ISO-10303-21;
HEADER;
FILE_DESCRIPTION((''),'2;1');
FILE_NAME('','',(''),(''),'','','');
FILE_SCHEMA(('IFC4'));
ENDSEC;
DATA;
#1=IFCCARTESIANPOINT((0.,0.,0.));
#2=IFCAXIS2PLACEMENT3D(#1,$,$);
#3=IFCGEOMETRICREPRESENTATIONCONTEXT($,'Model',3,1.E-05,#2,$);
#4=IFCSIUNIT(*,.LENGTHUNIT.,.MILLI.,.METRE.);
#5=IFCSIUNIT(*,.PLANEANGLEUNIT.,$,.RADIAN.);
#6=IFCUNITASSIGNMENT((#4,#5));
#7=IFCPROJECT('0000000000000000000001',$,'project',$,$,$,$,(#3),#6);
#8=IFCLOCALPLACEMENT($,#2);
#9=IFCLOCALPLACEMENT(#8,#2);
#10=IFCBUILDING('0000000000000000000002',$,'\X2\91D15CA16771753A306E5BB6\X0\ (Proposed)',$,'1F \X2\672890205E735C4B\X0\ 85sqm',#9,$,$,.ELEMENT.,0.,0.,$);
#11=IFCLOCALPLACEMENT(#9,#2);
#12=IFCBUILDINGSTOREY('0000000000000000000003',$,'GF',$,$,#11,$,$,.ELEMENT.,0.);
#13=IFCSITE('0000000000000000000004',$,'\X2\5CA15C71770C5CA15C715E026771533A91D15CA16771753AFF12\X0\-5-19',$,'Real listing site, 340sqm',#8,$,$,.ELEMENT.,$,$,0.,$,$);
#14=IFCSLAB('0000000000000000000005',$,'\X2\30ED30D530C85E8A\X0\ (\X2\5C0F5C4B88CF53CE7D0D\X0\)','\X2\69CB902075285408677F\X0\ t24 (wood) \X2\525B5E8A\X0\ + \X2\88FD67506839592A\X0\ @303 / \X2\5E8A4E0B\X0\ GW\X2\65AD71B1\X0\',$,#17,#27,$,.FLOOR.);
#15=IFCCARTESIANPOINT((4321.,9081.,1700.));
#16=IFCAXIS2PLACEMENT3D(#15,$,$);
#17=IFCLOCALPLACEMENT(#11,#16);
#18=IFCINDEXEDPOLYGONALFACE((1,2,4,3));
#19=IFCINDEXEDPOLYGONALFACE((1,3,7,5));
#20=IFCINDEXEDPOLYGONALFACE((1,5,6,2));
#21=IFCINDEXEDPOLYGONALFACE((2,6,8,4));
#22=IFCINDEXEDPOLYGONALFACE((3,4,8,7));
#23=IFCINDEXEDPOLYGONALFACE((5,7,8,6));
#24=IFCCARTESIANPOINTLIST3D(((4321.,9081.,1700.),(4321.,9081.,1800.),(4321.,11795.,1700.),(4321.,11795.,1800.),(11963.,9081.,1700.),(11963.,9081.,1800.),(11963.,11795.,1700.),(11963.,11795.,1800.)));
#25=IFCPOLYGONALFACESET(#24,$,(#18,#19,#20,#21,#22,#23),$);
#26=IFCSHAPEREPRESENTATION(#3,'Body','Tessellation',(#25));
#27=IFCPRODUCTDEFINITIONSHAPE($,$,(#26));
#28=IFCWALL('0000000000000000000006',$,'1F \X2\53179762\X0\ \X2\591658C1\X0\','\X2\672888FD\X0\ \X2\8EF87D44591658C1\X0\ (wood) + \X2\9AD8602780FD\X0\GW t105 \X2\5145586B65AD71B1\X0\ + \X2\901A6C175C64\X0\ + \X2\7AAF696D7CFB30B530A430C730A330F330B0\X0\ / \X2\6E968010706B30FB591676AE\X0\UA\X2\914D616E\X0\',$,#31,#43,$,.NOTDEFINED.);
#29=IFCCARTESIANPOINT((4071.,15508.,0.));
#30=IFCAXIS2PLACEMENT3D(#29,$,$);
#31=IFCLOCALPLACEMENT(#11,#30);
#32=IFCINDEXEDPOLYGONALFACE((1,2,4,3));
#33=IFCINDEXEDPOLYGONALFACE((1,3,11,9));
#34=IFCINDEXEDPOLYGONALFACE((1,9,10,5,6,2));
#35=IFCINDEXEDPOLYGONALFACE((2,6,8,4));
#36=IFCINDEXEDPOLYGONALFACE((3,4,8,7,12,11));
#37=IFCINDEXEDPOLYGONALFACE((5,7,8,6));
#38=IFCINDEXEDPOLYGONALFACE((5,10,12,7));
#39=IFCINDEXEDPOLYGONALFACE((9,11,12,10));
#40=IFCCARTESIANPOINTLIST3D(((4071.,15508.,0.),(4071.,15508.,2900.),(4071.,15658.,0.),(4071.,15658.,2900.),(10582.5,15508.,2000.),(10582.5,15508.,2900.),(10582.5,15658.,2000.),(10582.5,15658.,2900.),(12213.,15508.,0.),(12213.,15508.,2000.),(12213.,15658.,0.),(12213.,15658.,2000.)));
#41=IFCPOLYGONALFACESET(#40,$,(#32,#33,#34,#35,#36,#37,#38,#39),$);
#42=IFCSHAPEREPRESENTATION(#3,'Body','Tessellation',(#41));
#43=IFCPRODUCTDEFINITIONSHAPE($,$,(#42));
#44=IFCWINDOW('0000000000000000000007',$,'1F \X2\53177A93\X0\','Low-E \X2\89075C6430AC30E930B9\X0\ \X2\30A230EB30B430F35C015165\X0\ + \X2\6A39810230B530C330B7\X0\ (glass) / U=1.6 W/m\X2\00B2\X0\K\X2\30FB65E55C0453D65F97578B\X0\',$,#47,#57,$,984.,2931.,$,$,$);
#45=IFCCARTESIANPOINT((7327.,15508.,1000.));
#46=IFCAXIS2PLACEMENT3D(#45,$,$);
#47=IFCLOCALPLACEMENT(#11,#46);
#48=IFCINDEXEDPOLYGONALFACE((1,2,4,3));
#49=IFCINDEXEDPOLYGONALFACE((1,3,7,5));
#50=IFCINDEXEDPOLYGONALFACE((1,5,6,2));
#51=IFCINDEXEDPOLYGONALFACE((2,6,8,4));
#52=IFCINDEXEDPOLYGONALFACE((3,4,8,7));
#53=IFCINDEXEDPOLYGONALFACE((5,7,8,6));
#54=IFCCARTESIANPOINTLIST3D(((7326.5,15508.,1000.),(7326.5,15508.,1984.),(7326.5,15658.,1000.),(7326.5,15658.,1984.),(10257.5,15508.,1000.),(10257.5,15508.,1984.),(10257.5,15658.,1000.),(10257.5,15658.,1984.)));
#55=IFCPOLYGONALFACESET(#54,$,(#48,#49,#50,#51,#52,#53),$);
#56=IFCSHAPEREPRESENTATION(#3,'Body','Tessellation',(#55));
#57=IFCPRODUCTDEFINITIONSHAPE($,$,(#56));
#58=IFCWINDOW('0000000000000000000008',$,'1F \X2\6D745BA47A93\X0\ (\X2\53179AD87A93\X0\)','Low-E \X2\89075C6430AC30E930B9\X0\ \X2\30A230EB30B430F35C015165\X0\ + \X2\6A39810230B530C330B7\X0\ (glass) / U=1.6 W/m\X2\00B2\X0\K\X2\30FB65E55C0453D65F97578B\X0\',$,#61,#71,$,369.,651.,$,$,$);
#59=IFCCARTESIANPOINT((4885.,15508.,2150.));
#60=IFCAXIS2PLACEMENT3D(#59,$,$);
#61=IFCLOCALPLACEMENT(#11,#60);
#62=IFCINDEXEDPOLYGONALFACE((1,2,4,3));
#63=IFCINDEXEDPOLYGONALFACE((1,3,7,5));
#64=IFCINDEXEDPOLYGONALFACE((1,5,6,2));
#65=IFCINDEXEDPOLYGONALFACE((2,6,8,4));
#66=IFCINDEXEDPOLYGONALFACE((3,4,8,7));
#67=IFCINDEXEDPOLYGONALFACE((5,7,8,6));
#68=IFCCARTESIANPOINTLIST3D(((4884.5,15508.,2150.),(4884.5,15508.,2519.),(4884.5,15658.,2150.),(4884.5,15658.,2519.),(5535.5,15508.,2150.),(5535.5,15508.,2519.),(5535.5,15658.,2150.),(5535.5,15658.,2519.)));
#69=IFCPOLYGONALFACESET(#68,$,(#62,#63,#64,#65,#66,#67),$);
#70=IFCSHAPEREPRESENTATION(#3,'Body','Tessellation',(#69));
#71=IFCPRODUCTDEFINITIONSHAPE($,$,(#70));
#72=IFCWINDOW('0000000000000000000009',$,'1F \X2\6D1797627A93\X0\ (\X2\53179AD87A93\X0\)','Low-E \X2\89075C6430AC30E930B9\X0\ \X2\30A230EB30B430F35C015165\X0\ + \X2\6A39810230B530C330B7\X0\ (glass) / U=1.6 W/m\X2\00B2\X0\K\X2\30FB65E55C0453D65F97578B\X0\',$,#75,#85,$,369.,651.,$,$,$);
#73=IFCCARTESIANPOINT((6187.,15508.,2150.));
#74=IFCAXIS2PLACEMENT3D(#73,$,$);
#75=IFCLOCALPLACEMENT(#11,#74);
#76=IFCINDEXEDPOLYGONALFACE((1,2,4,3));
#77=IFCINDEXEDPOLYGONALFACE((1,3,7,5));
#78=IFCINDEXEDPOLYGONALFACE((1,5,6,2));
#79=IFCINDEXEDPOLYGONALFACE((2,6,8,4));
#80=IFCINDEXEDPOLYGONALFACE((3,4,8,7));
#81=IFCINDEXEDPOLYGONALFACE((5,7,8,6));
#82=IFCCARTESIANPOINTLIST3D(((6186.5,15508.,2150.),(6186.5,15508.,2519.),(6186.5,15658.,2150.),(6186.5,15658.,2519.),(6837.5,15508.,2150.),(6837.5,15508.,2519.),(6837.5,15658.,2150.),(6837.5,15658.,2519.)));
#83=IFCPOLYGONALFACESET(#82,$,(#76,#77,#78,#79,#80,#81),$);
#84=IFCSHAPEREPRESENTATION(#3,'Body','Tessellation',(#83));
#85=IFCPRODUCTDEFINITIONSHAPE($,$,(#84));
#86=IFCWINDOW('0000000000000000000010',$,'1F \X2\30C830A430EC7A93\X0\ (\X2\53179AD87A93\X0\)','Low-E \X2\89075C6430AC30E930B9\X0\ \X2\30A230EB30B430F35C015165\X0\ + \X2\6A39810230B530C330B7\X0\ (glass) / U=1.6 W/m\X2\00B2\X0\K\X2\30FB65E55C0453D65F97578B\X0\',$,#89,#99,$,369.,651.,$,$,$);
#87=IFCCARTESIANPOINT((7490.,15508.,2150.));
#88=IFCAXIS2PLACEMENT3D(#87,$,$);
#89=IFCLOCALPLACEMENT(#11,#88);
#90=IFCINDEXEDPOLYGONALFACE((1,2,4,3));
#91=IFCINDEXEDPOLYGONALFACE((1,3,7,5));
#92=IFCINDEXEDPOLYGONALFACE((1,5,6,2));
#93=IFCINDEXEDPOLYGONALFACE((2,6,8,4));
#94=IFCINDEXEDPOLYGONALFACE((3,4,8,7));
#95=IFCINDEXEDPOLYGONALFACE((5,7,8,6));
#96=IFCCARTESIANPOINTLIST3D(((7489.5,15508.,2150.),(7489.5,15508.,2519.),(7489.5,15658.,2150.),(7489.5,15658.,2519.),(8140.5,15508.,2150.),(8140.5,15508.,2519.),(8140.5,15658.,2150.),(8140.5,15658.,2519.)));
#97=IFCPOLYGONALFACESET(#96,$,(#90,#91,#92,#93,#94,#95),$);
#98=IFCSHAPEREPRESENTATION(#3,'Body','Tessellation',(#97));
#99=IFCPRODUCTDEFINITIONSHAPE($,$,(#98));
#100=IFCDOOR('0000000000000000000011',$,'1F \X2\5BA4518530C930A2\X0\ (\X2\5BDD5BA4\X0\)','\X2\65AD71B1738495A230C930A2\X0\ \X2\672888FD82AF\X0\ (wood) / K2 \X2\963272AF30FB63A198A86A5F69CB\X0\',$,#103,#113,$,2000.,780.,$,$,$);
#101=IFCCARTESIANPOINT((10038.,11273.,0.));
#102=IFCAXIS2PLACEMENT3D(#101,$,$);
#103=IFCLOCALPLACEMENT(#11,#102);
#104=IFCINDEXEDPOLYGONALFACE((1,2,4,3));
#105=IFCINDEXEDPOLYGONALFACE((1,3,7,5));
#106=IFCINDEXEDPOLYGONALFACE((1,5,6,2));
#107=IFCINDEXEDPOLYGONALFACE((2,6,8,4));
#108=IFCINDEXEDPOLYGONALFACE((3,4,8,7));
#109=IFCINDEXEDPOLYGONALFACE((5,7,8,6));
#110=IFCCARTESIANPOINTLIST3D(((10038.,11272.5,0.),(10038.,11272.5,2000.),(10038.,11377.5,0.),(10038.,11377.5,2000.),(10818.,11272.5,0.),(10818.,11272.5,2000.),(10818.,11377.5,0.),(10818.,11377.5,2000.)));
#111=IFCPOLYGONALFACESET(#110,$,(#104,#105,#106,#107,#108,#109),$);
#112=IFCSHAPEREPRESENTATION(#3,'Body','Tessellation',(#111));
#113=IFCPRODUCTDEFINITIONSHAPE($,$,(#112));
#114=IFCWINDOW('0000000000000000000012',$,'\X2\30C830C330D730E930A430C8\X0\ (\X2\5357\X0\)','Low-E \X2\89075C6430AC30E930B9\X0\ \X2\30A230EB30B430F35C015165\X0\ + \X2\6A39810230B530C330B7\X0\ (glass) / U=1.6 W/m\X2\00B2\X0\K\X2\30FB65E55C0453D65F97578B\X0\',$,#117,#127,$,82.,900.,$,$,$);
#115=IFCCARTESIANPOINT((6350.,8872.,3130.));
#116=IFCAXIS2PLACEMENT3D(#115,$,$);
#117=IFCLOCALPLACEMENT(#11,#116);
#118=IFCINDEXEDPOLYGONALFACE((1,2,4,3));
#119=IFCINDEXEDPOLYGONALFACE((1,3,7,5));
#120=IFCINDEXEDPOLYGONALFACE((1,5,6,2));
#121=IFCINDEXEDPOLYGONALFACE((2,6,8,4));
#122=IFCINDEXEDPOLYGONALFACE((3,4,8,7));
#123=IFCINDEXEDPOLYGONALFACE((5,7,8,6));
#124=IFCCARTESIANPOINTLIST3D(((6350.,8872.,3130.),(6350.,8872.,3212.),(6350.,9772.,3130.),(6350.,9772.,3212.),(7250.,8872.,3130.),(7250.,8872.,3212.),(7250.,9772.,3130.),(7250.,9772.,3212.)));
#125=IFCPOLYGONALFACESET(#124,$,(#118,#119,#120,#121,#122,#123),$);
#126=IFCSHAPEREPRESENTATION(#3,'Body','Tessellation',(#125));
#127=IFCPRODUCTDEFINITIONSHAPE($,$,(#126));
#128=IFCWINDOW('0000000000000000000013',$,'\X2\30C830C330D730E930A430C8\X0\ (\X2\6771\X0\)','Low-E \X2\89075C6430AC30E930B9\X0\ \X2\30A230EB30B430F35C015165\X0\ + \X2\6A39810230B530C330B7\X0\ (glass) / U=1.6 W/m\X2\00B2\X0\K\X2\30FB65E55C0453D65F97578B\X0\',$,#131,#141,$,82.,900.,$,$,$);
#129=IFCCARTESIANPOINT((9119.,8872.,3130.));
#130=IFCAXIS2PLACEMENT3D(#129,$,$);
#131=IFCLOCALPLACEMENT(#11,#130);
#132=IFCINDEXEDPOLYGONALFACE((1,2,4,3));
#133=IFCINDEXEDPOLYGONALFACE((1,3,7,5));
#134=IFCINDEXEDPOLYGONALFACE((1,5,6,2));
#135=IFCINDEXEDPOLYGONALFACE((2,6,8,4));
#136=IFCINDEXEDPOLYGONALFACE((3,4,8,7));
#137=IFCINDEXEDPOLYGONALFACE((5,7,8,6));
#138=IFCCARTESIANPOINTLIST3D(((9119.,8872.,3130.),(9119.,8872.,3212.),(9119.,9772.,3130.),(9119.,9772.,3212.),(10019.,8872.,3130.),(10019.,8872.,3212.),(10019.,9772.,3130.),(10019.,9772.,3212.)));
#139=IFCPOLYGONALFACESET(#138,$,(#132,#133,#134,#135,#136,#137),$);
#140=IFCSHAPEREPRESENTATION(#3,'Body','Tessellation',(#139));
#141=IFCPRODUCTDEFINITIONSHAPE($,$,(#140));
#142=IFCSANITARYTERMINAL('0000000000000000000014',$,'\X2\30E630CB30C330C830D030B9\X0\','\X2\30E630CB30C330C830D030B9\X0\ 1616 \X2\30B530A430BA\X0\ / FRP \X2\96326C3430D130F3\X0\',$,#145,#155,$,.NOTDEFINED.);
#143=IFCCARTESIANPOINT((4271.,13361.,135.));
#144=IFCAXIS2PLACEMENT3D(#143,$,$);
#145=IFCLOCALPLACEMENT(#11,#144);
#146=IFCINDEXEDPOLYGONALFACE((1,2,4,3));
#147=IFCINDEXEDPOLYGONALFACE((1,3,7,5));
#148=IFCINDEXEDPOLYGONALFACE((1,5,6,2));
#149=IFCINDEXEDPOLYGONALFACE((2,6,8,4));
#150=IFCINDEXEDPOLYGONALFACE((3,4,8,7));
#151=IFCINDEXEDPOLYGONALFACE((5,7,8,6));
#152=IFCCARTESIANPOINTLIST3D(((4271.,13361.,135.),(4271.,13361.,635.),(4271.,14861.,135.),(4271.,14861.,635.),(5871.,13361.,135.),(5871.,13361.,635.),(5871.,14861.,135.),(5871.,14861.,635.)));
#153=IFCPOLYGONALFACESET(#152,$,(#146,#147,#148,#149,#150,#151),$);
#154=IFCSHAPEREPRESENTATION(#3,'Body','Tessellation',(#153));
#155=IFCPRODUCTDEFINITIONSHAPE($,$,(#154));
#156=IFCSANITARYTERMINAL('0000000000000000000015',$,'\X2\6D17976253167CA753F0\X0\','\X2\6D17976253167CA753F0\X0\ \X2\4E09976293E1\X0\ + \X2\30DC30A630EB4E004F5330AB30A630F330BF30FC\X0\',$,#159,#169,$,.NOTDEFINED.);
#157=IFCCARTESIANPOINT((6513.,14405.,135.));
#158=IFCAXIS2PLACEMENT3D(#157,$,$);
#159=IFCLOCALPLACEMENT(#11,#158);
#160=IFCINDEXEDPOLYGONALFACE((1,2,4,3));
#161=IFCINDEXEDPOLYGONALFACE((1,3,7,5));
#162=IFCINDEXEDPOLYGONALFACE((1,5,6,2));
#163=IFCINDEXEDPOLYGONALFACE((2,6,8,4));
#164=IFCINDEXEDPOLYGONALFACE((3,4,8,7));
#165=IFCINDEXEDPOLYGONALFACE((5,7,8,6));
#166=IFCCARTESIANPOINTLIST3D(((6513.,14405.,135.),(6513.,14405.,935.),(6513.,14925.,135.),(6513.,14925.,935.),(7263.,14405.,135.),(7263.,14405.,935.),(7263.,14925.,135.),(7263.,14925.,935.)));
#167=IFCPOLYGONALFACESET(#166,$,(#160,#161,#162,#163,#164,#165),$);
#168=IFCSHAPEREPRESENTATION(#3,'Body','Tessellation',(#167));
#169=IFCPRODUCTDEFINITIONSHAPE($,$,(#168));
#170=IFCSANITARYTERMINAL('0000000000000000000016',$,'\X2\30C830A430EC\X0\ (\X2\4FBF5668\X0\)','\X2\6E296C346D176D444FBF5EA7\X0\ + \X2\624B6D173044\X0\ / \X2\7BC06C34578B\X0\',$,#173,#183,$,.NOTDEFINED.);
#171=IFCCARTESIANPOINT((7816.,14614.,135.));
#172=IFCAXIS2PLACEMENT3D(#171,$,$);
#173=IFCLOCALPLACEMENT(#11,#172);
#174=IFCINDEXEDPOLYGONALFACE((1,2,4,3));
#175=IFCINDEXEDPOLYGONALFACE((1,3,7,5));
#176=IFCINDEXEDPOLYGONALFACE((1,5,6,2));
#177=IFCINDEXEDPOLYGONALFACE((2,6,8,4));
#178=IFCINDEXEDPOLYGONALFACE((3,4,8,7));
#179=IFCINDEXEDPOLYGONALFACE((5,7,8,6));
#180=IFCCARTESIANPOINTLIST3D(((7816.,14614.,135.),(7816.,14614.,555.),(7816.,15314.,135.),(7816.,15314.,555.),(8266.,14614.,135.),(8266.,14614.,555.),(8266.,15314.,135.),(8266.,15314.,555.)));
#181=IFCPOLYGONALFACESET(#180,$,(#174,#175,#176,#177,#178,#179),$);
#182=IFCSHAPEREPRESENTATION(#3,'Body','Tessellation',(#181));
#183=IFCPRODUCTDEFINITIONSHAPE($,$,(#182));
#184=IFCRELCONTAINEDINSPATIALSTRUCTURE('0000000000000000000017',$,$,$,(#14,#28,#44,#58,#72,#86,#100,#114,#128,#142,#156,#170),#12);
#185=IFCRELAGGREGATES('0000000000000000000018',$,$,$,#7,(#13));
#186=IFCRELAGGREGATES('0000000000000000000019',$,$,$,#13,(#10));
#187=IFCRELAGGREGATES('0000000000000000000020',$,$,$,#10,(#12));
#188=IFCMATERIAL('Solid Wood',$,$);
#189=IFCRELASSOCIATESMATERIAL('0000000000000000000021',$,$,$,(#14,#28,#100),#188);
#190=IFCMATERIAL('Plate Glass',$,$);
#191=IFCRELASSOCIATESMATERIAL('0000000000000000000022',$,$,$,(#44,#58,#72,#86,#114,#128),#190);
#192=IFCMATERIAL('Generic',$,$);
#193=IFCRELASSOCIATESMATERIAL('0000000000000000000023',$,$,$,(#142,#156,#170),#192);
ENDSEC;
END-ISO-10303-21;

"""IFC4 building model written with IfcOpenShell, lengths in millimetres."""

from ifc_helpers import new_model, si_unit, frame, frame_2d, origin, place, context, project, spatial, rectangle, extrude, material, element, fill, save


model = new_model("IFC4")

# Units and contexts
model_context = context("Model", 3, precision=1e-05, world=origin())
ifc_project = project(units=[si_unit("LENGTHUNIT", "METRE", prefix="MILLI"), si_unit("PLANEANGLEUNIT", "RADIAN")], contexts=[model_context])

# Site, building, storey
site_placement = place(None, origin())
site = spatial("IfcSite", under=ifc_project, at=site_placement, Name="岡山県岡山市東区金岡東町２-5-19", ObjectType="Real listing site, 340sqm", CompositionType="ELEMENT", RefElevation=0.0)
building_placement = place(site_placement, origin())
building = spatial("IfcBuilding", under=site, at=building_placement, Name="金岡東町の家 (Proposed)", ObjectType="1F 木造平屋 85sqm", CompositionType="ELEMENT", ElevationOfRefHeight=0.0, ElevationOfTerrain=0.0)
storey_placement = place(building_placement, origin())
storey = spatial("IfcBuildingStorey", under=building, at=storey_placement, Name="GF", CompositionType="ELEMENT", Elevation=0.0)

# Slab
ifc_material_1 = material(Name="Solid Wood")
slab_placement = place(storey_placement, frame((4321.0, 9081.0, 1700.0)))
element("IfcSlab", 1, at=slab_placement, inside=storey, material=ifc_material_1, Name="ロフト床 (小屋裏収納)", Description="構造用合板 t24 (wood) 剛床 + 製材根太 @303 / 床下 GW断熱", PredefinedType="FLOOR", context=model_context, shape_type="SweptSolid", body=[
    extrude(rectangle(XDim=7642.0, YDim=2714.0, at=frame_2d((3821.0, 1357.0))), frame((4321.0, 9081.0, 1700.0)), (0.0, 0.0, 1.0), 100.0),
])

# Wall, openings, windows
wall_1_placement = place(storey_placement, frame((4071.0, 15508.0, 0.0)))
wall_1 = element("IfcWall", 2, at=wall_1_placement, inside=storey, material=ifc_material_1, Name="1F 北面 外壁", Description="木製 軸組外壁 (wood) + 高性能GW t105 充填断熱 + 通気層 + 窯業系サイディング / 準耐火・外皮UA配慮", PredefinedType="NOTDEFINED", context=model_context, shape_type="SweptSolid", body=[
    extrude(rectangle(XDim=8142.0, YDim=150.0, at=frame_2d((4071.0, 75.0))), frame((4071.0, 15508.0, 0.0)), (0.0, 0.0, 1.0), 2900.0),
])
opening_1_placement = place(storey_placement, frame((7327.0, 15508.0, 1000.0)))
opening_1 = element("IfcOpeningElement", 3, at=opening_1_placement, cuts=wall_1, PredefinedType="NOTDEFINED", context=model_context, shape_type="SweptSolid", body=[
    extrude(rectangle(XDim=2931.0, YDim=150.0, at=frame_2d((1465.0, 75.0))), frame((7327.0, 15508.0, 1000.0)), (0.0, 0.0, 1.0), 984.0),
])
opening_2_placement = place(storey_placement, frame((4885.0, 15508.0, 2150.0)))
opening_2 = element("IfcOpeningElement", 4, at=opening_2_placement, cuts=wall_1, PredefinedType="NOTDEFINED", context=model_context, shape_type="SweptSolid", body=[
    extrude(rectangle(XDim=651.0, YDim=150.0, at=frame_2d((325.0, 75.0))), frame((4885.0, 15508.0, 2150.0)), (0.0, 0.0, 1.0), 369.0),
])
opening_3_placement = place(storey_placement, frame((6187.0, 15508.0, 2150.0)))
opening_3 = element("IfcOpeningElement", 5, at=opening_3_placement, cuts=wall_1, PredefinedType="NOTDEFINED", context=model_context, shape_type="SweptSolid", body=[
    extrude(rectangle(XDim=651.0, YDim=150.0, at=frame_2d((325.0, 75.0))), frame((6187.0, 15508.0, 2150.0)), (0.0, 0.0, 1.0), 369.0),
])
opening_4_placement = place(storey_placement, frame((7490.0, 15508.0, 2150.0)))
opening_4 = element("IfcOpeningElement", 6, at=opening_4_placement, cuts=wall_1, PredefinedType="NOTDEFINED", context=model_context, shape_type="SweptSolid", body=[
    extrude(rectangle(XDim=651.0, YDim=150.0, at=frame_2d((325.0, 75.0))), frame((7490.0, 15508.0, 2150.0)), (0.0, 0.0, 1.0), 369.0),
])
ifc_material_2 = material(Name="Plate Glass")
window_1_placement = place(storey_placement, frame((7327.0, 15508.0, 1000.0)))
window_1 = element("IfcWindow", 7, at=window_1_placement, inside=storey, material=ifc_material_2, Name="1F 北窓", Description="Low-E 複層ガラス アルゴン封入 + 樹脂サッシ (glass) / U=1.6 W/m²K・日射取得型", OverallHeight=984.0, OverallWidth=2931.0, context=model_context, shape_type="SweptSolid", body=[
    extrude(rectangle(XDim=2931.0, YDim=150.0, at=frame_2d((1465.0, 75.0))), frame((7327.0, 15508.0, 1000.0)), (0.0, 0.0, 1.0), 984.0),
])
fill(opening_1, window_1)
window_2_placement = place(storey_placement, frame((4885.0, 15508.0, 2150.0)))
window_2 = element("IfcWindow", 8, at=window_2_placement, inside=storey, material=ifc_material_2, Name="1F 浴室窓 (北高窓)", Description="Low-E 複層ガラス アルゴン封入 + 樹脂サッシ (glass) / U=1.6 W/m²K・日射取得型", OverallHeight=369.0, OverallWidth=651.0, context=model_context, shape_type="SweptSolid", body=[
    extrude(rectangle(XDim=651.0, YDim=150.0, at=frame_2d((325.0, 75.0))), frame((4885.0, 15508.0, 2150.0)), (0.0, 0.0, 1.0), 369.0),
])
fill(opening_2, window_2)
window_3_placement = place(storey_placement, frame((6187.0, 15508.0, 2150.0)))
window_3 = element("IfcWindow", 9, at=window_3_placement, inside=storey, material=ifc_material_2, Name="1F 洗面窓 (北高窓)", Description="Low-E 複層ガラス アルゴン封入 + 樹脂サッシ (glass) / U=1.6 W/m²K・日射取得型", OverallHeight=369.0, OverallWidth=651.0, context=model_context, shape_type="SweptSolid", body=[
    extrude(rectangle(XDim=651.0, YDim=150.0, at=frame_2d((325.0, 75.0))), frame((6187.0, 15508.0, 2150.0)), (0.0, 0.0, 1.0), 369.0),
])
fill(opening_3, window_3)
window_4_placement = place(storey_placement, frame((7490.0, 15508.0, 2150.0)))
window_4 = element("IfcWindow", 10, at=window_4_placement, inside=storey, material=ifc_material_2, Name="1F トイレ窓 (北高窓)", Description="Low-E 複層ガラス アルゴン封入 + 樹脂サッシ (glass) / U=1.6 W/m²K・日射取得型", OverallHeight=369.0, OverallWidth=651.0, context=model_context, shape_type="SweptSolid", body=[
    extrude(rectangle(XDim=651.0, YDim=150.0, at=frame_2d((325.0, 75.0))), frame((7490.0, 15508.0, 2150.0)), (0.0, 0.0, 1.0), 369.0),
])
fill(opening_4, window_4)

# Door
door_1_placement = place(storey_placement, frame((10038.0, 11273.0, 0.0)))
element("IfcDoor", 11, at=door_1_placement, inside=storey, material=ifc_material_1, Name="1F 室内ドア (寝室)", Description="断熱玄関ドア 木製芯 (wood) / K2 防犯・採風機構", OverallHeight=2000.0, OverallWidth=780.0, context=model_context, shape_type="SweptSolid", body=[
    extrude(rectangle(XDim=780.0, YDim=105.0, at=frame_2d((390.0, 52.0))), frame((10038.0, 11273.0, 0.0)), (0.0, 0.0, 1.0), 2000.0),
])

# Windows
window_5_placement = place(storey_placement, frame((6350.0, 8872.0, 3130.0)))
element("IfcWindow", 12, at=window_5_placement, inside=storey, material=ifc_material_2, Name="トップライト (南)", Description="Low-E 複層ガラス アルゴン封入 + 樹脂サッシ (glass) / U=1.6 W/m²K・日射取得型", OverallHeight=82.0, OverallWidth=900.0, context=model_context, shape_type="SweptSolid", body=[
    extrude(rectangle(XDim=900.0, YDim=900.0, at=frame_2d((450.0, 450.0))), frame((6350.0, 8872.0, 3130.0)), (0.0, 0.0, 1.0), 82.0),
])
window_6_placement = place(storey_placement, frame((9119.0, 8872.0, 3130.0)))
element("IfcWindow", 13, at=window_6_placement, inside=storey, material=ifc_material_2, Name="トップライト (東)", Description="Low-E 複層ガラス アルゴン封入 + 樹脂サッシ (glass) / U=1.6 W/m²K・日射取得型", OverallHeight=82.0, OverallWidth=900.0, context=model_context, shape_type="SweptSolid", body=[
    extrude(rectangle(XDim=900.0, YDim=900.0, at=frame_2d((450.0, 450.0))), frame((9119.0, 8872.0, 3130.0)), (0.0, 0.0, 1.0), 82.0),
])

# Sanitary terminals
ifc_material_3 = material(Name="Generic")
sanitary_terminal_1_placement = place(storey_placement, frame((4271.0, 13361.0, 135.0)))
element("IfcSanitaryTerminal", 14, at=sanitary_terminal_1_placement, inside=storey, material=ifc_material_3, Name="ユニットバス", Description="ユニットバス 1616 サイズ / FRP 防水パン", PredefinedType="NOTDEFINED", context=model_context, shape_type="SweptSolid", body=[
    extrude(rectangle(XDim=1600.0, YDim=1500.0, at=frame_2d((800.0, 750.0))), frame((4271.0, 13361.0, 135.0)), (0.0, 0.0, 1.0), 500.0),
])
sanitary_terminal_2_placement = place(storey_placement, frame((6513.0, 14405.0, 135.0)))
element("IfcSanitaryTerminal", 15, at=sanitary_terminal_2_placement, inside=storey, material=ifc_material_3, Name="洗面化粧台", Description="洗面化粧台 三面鏡 + ボウル一体カウンター", PredefinedType="NOTDEFINED", context=model_context, shape_type="SweptSolid", body=[
    extrude(rectangle(XDim=750.0, YDim=520.0, at=frame_2d((375.0, 260.0))), frame((6513.0, 14405.0, 135.0)), (0.0, 0.0, 1.0), 800.0),
])
sanitary_terminal_3_placement = place(storey_placement, frame((7816.0, 14614.0, 135.0)))
element("IfcSanitaryTerminal", 16, at=sanitary_terminal_3_placement, inside=storey, material=ifc_material_3, Name="トイレ (便器)", Description="温水洗浄便座 + 手洗い / 節水型", PredefinedType="NOTDEFINED", context=model_context, shape_type="SweptSolid", body=[
    extrude(rectangle(XDim=450.0, YDim=700.0, at=frame_2d((225.0, 350.0))), frame((7816.0, 14614.0, 135.0)), (0.0, 0.0, 1.0), 420.0),
])

save(model, "model.ifc")
